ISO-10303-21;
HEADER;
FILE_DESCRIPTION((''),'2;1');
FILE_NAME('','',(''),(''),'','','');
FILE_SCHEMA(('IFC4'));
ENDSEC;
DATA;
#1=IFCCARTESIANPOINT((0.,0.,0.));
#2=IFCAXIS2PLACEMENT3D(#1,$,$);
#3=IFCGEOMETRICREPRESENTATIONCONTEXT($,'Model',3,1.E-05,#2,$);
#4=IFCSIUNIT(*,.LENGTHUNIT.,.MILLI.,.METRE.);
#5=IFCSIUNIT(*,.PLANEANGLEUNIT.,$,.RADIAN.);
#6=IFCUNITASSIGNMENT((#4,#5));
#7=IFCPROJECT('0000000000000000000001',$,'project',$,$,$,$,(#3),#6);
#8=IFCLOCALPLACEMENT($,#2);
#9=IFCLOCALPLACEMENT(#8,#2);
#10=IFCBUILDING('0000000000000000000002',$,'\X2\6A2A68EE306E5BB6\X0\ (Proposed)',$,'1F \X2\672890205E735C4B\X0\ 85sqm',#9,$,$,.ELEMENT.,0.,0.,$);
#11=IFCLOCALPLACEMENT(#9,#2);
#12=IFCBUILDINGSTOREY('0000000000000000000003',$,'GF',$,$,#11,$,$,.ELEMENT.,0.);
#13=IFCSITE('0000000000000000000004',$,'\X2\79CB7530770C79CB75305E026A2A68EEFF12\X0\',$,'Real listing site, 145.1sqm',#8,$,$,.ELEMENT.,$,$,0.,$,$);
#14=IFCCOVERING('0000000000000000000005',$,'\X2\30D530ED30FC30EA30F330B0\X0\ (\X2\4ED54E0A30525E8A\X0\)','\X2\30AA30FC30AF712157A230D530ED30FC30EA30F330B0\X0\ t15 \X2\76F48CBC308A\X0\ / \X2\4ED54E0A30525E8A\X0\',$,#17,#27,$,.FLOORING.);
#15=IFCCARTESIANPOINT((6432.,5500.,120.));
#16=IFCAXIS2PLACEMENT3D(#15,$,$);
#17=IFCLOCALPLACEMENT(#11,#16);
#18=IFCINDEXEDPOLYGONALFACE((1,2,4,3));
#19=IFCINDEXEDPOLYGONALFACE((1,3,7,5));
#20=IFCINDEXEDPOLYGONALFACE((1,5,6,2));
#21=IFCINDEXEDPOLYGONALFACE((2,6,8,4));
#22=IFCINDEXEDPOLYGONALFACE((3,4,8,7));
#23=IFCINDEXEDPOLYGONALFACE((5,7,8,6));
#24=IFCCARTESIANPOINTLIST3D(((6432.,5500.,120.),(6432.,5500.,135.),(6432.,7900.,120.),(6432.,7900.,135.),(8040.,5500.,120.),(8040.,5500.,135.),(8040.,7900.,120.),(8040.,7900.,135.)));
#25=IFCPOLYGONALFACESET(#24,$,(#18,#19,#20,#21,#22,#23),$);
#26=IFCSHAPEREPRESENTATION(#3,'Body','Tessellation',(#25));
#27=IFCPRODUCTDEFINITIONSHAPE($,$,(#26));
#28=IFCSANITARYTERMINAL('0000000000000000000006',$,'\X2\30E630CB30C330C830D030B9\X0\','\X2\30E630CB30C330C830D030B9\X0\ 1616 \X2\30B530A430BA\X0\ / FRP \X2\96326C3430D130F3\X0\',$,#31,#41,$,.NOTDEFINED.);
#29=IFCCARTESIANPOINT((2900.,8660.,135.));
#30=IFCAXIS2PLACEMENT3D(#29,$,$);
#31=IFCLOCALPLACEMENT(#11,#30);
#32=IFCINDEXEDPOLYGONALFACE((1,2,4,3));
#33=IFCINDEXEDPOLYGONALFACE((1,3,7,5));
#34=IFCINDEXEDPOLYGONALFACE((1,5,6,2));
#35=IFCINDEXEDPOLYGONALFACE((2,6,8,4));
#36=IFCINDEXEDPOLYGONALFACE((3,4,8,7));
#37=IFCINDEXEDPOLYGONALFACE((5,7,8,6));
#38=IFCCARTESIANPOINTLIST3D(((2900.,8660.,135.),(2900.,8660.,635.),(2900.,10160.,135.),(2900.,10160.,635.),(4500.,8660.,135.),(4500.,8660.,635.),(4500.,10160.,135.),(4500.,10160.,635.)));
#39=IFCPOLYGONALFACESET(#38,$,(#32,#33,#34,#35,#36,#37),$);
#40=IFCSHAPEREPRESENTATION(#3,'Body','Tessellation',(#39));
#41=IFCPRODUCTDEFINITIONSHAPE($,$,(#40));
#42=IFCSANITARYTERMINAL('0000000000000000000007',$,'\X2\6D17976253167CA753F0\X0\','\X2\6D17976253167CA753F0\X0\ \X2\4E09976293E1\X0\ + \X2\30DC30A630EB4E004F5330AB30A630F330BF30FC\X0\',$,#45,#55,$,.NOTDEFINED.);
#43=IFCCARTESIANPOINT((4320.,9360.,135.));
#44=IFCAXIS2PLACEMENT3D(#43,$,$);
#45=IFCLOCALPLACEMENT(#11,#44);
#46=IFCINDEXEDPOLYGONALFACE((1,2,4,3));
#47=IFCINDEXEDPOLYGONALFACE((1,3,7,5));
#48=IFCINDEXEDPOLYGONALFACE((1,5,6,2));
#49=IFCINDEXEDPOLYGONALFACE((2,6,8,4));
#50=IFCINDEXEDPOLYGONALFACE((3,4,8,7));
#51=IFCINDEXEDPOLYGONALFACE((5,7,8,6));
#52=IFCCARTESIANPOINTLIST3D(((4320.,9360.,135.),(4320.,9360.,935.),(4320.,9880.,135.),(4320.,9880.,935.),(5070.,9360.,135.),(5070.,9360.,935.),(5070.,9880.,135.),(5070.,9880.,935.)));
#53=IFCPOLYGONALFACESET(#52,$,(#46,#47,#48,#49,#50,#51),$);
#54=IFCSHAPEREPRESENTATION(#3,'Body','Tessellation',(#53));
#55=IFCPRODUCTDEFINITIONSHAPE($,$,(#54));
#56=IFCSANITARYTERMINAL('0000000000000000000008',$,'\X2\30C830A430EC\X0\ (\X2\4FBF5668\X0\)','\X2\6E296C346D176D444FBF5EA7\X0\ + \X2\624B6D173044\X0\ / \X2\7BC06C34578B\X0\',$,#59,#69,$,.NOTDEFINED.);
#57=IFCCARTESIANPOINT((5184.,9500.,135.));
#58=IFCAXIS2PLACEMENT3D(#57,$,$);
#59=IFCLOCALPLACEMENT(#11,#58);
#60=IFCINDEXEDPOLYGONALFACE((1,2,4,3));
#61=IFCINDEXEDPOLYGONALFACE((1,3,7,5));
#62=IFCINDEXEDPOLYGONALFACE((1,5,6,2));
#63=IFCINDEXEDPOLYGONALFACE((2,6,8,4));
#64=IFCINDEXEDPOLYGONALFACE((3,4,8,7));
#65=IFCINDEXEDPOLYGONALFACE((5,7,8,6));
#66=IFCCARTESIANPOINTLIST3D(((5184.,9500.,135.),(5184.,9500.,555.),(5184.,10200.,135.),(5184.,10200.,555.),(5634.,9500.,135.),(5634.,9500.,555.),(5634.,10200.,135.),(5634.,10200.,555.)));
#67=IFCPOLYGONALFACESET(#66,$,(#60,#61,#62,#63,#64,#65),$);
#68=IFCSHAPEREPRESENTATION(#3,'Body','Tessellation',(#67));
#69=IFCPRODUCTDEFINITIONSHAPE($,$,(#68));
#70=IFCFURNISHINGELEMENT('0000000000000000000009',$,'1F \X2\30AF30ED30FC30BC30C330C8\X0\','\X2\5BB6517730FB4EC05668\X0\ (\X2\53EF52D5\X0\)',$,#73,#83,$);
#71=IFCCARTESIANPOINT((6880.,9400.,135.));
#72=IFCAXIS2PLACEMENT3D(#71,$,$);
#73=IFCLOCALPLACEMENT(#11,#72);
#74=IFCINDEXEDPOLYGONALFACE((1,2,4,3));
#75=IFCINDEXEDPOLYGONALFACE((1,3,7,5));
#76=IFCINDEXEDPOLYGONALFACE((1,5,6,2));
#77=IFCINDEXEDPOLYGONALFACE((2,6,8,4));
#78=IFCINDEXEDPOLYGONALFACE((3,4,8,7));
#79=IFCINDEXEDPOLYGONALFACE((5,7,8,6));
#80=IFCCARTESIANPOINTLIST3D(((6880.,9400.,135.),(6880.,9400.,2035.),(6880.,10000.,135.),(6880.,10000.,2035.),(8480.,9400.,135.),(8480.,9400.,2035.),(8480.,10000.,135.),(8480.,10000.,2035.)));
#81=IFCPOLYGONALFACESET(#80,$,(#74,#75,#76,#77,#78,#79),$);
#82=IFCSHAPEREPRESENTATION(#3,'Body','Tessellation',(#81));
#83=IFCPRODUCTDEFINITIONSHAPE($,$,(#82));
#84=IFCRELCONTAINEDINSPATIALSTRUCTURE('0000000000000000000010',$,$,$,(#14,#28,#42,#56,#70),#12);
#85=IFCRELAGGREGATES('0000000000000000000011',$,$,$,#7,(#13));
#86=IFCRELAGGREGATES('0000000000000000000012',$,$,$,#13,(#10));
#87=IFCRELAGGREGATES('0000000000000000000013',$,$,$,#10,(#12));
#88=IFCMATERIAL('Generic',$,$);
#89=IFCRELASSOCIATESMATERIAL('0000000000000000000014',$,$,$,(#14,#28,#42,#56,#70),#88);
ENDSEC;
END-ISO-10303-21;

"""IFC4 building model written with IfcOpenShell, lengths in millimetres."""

from ifc_helpers import new_model, si_unit, frame, frame_2d, origin, place, context, project, spatial, rectangle, extrude, material, element, save


model = new_model("IFC4")

# Units and contexts
model_context = context("Model", 3, precision=1e-05, world=origin())
ifc_project = project(units=[si_unit("LENGTHUNIT", "METRE", prefix="MILLI"), si_unit("PLANEANGLEUNIT", "RADIAN")], contexts=[model_context])

# Site, building, storey
site_placement = place(None, origin())
site = spatial("IfcSite", under=ifc_project, at=site_placement, Name="秋田県秋田市横森２", ObjectType="Real listing site, 145.1sqm", CompositionType="ELEMENT", RefElevation=0.0)
building_placement = place(site_placement, origin())
building = spatial("IfcBuilding", under=site, at=building_placement, Name="横森の家 (Proposed)", ObjectType="1F 木造平屋 85sqm", CompositionType="ELEMENT", ElevationOfRefHeight=0.0, ElevationOfTerrain=0.0)
storey_placement = place(building_placement, origin())
storey = spatial("IfcBuildingStorey", under=building, at=storey_placement, Name="GF", CompositionType="ELEMENT", Elevation=0.0)

# Covering
ifc_material_1 = material(Name="Generic")
covering_1_placement = place(storey_placement, frame((6432.0, 5500.0, 120.0)))
element("IfcCovering", 1, at=covering_1_placement, inside=storey, material=ifc_material_1, Name="フローリング (仕上げ床)", Description="オーク無垢フローリング t15 直貼り / 仕上げ床", PredefinedType="FLOORING", context=model_context, shape_type="SweptSolid", body=[
    extrude(rectangle(XDim=1608.0, YDim=2400.0, at=frame_2d((804.0, 1200.0))), frame((6432.0, 5500.0, 120.0)), (0.0, 0.0, 1.0), 15.0),
])

# Sanitary terminals
sanitary_terminal_1_placement = place(storey_placement, frame((2900.0, 8660.0, 135.0)))
element("IfcSanitaryTerminal", 2, at=sanitary_terminal_1_placement, inside=storey, material=ifc_material_1, Name="ユニットバス", Description="ユニットバス 1616 サイズ / FRP 防水パン", PredefinedType="NOTDEFINED", context=model_context, shape_type="SweptSolid", body=[
    extrude(rectangle(XDim=1600.0, YDim=1500.0, at=frame_2d((800.0, 750.0))), frame((2900.0, 8660.0, 135.0)), (0.0, 0.0, 1.0), 500.0),
])
sanitary_terminal_2_placement = place(storey_placement, frame((4320.0, 9360.0, 135.0)))
element("IfcSanitaryTerminal", 3, at=sanitary_terminal_2_placement, inside=storey, material=ifc_material_1, Name="洗面化粧台", Description="洗面化粧台 三面鏡 + ボウル一体カウンター", PredefinedType="NOTDEFINED", context=model_context, shape_type="SweptSolid", body=[
    extrude(rectangle(XDim=750.0, YDim=520.0, at=frame_2d((375.0, 260.0))), frame((4320.0, 9360.0, 135.0)), (0.0, 0.0, 1.0), 800.0),
])
sanitary_terminal_3_placement = place(storey_placement, frame((5184.0, 9500.0, 135.0)))
element("IfcSanitaryTerminal", 4, at=sanitary_terminal_3_placement, inside=storey, material=ifc_material_1, Name="トイレ (便器)", Description="温水洗浄便座 + 手洗い / 節水型", PredefinedType="NOTDEFINED", context=model_context, shape_type="SweptSolid", body=[
    extrude(rectangle(XDim=450.0, YDim=700.0, at=frame_2d((225.0, 350.0))), frame((5184.0, 9500.0, 135.0)), (0.0, 0.0, 1.0), 420.0),
])

# Furnishing element
furnishing_placement = place(storey_placement, frame((6880.0, 9400.0, 135.0)))
element("IfcFurnishingElement", 5, at=furnishing_placement, inside=storey, material=ifc_material_1, Name="1F クローゼット", Description="家具・什器 (可動)", context=model_context, shape_type="SweptSolid", body=[
    extrude(rectangle(XDim=1600.0, YDim=600.0, at=frame_2d((800.0, 300.0))), frame((6880.0, 9400.0, 135.0)), (0.0, 0.0, 1.0), 1900.0),
])

save(model, "model.ifc")
